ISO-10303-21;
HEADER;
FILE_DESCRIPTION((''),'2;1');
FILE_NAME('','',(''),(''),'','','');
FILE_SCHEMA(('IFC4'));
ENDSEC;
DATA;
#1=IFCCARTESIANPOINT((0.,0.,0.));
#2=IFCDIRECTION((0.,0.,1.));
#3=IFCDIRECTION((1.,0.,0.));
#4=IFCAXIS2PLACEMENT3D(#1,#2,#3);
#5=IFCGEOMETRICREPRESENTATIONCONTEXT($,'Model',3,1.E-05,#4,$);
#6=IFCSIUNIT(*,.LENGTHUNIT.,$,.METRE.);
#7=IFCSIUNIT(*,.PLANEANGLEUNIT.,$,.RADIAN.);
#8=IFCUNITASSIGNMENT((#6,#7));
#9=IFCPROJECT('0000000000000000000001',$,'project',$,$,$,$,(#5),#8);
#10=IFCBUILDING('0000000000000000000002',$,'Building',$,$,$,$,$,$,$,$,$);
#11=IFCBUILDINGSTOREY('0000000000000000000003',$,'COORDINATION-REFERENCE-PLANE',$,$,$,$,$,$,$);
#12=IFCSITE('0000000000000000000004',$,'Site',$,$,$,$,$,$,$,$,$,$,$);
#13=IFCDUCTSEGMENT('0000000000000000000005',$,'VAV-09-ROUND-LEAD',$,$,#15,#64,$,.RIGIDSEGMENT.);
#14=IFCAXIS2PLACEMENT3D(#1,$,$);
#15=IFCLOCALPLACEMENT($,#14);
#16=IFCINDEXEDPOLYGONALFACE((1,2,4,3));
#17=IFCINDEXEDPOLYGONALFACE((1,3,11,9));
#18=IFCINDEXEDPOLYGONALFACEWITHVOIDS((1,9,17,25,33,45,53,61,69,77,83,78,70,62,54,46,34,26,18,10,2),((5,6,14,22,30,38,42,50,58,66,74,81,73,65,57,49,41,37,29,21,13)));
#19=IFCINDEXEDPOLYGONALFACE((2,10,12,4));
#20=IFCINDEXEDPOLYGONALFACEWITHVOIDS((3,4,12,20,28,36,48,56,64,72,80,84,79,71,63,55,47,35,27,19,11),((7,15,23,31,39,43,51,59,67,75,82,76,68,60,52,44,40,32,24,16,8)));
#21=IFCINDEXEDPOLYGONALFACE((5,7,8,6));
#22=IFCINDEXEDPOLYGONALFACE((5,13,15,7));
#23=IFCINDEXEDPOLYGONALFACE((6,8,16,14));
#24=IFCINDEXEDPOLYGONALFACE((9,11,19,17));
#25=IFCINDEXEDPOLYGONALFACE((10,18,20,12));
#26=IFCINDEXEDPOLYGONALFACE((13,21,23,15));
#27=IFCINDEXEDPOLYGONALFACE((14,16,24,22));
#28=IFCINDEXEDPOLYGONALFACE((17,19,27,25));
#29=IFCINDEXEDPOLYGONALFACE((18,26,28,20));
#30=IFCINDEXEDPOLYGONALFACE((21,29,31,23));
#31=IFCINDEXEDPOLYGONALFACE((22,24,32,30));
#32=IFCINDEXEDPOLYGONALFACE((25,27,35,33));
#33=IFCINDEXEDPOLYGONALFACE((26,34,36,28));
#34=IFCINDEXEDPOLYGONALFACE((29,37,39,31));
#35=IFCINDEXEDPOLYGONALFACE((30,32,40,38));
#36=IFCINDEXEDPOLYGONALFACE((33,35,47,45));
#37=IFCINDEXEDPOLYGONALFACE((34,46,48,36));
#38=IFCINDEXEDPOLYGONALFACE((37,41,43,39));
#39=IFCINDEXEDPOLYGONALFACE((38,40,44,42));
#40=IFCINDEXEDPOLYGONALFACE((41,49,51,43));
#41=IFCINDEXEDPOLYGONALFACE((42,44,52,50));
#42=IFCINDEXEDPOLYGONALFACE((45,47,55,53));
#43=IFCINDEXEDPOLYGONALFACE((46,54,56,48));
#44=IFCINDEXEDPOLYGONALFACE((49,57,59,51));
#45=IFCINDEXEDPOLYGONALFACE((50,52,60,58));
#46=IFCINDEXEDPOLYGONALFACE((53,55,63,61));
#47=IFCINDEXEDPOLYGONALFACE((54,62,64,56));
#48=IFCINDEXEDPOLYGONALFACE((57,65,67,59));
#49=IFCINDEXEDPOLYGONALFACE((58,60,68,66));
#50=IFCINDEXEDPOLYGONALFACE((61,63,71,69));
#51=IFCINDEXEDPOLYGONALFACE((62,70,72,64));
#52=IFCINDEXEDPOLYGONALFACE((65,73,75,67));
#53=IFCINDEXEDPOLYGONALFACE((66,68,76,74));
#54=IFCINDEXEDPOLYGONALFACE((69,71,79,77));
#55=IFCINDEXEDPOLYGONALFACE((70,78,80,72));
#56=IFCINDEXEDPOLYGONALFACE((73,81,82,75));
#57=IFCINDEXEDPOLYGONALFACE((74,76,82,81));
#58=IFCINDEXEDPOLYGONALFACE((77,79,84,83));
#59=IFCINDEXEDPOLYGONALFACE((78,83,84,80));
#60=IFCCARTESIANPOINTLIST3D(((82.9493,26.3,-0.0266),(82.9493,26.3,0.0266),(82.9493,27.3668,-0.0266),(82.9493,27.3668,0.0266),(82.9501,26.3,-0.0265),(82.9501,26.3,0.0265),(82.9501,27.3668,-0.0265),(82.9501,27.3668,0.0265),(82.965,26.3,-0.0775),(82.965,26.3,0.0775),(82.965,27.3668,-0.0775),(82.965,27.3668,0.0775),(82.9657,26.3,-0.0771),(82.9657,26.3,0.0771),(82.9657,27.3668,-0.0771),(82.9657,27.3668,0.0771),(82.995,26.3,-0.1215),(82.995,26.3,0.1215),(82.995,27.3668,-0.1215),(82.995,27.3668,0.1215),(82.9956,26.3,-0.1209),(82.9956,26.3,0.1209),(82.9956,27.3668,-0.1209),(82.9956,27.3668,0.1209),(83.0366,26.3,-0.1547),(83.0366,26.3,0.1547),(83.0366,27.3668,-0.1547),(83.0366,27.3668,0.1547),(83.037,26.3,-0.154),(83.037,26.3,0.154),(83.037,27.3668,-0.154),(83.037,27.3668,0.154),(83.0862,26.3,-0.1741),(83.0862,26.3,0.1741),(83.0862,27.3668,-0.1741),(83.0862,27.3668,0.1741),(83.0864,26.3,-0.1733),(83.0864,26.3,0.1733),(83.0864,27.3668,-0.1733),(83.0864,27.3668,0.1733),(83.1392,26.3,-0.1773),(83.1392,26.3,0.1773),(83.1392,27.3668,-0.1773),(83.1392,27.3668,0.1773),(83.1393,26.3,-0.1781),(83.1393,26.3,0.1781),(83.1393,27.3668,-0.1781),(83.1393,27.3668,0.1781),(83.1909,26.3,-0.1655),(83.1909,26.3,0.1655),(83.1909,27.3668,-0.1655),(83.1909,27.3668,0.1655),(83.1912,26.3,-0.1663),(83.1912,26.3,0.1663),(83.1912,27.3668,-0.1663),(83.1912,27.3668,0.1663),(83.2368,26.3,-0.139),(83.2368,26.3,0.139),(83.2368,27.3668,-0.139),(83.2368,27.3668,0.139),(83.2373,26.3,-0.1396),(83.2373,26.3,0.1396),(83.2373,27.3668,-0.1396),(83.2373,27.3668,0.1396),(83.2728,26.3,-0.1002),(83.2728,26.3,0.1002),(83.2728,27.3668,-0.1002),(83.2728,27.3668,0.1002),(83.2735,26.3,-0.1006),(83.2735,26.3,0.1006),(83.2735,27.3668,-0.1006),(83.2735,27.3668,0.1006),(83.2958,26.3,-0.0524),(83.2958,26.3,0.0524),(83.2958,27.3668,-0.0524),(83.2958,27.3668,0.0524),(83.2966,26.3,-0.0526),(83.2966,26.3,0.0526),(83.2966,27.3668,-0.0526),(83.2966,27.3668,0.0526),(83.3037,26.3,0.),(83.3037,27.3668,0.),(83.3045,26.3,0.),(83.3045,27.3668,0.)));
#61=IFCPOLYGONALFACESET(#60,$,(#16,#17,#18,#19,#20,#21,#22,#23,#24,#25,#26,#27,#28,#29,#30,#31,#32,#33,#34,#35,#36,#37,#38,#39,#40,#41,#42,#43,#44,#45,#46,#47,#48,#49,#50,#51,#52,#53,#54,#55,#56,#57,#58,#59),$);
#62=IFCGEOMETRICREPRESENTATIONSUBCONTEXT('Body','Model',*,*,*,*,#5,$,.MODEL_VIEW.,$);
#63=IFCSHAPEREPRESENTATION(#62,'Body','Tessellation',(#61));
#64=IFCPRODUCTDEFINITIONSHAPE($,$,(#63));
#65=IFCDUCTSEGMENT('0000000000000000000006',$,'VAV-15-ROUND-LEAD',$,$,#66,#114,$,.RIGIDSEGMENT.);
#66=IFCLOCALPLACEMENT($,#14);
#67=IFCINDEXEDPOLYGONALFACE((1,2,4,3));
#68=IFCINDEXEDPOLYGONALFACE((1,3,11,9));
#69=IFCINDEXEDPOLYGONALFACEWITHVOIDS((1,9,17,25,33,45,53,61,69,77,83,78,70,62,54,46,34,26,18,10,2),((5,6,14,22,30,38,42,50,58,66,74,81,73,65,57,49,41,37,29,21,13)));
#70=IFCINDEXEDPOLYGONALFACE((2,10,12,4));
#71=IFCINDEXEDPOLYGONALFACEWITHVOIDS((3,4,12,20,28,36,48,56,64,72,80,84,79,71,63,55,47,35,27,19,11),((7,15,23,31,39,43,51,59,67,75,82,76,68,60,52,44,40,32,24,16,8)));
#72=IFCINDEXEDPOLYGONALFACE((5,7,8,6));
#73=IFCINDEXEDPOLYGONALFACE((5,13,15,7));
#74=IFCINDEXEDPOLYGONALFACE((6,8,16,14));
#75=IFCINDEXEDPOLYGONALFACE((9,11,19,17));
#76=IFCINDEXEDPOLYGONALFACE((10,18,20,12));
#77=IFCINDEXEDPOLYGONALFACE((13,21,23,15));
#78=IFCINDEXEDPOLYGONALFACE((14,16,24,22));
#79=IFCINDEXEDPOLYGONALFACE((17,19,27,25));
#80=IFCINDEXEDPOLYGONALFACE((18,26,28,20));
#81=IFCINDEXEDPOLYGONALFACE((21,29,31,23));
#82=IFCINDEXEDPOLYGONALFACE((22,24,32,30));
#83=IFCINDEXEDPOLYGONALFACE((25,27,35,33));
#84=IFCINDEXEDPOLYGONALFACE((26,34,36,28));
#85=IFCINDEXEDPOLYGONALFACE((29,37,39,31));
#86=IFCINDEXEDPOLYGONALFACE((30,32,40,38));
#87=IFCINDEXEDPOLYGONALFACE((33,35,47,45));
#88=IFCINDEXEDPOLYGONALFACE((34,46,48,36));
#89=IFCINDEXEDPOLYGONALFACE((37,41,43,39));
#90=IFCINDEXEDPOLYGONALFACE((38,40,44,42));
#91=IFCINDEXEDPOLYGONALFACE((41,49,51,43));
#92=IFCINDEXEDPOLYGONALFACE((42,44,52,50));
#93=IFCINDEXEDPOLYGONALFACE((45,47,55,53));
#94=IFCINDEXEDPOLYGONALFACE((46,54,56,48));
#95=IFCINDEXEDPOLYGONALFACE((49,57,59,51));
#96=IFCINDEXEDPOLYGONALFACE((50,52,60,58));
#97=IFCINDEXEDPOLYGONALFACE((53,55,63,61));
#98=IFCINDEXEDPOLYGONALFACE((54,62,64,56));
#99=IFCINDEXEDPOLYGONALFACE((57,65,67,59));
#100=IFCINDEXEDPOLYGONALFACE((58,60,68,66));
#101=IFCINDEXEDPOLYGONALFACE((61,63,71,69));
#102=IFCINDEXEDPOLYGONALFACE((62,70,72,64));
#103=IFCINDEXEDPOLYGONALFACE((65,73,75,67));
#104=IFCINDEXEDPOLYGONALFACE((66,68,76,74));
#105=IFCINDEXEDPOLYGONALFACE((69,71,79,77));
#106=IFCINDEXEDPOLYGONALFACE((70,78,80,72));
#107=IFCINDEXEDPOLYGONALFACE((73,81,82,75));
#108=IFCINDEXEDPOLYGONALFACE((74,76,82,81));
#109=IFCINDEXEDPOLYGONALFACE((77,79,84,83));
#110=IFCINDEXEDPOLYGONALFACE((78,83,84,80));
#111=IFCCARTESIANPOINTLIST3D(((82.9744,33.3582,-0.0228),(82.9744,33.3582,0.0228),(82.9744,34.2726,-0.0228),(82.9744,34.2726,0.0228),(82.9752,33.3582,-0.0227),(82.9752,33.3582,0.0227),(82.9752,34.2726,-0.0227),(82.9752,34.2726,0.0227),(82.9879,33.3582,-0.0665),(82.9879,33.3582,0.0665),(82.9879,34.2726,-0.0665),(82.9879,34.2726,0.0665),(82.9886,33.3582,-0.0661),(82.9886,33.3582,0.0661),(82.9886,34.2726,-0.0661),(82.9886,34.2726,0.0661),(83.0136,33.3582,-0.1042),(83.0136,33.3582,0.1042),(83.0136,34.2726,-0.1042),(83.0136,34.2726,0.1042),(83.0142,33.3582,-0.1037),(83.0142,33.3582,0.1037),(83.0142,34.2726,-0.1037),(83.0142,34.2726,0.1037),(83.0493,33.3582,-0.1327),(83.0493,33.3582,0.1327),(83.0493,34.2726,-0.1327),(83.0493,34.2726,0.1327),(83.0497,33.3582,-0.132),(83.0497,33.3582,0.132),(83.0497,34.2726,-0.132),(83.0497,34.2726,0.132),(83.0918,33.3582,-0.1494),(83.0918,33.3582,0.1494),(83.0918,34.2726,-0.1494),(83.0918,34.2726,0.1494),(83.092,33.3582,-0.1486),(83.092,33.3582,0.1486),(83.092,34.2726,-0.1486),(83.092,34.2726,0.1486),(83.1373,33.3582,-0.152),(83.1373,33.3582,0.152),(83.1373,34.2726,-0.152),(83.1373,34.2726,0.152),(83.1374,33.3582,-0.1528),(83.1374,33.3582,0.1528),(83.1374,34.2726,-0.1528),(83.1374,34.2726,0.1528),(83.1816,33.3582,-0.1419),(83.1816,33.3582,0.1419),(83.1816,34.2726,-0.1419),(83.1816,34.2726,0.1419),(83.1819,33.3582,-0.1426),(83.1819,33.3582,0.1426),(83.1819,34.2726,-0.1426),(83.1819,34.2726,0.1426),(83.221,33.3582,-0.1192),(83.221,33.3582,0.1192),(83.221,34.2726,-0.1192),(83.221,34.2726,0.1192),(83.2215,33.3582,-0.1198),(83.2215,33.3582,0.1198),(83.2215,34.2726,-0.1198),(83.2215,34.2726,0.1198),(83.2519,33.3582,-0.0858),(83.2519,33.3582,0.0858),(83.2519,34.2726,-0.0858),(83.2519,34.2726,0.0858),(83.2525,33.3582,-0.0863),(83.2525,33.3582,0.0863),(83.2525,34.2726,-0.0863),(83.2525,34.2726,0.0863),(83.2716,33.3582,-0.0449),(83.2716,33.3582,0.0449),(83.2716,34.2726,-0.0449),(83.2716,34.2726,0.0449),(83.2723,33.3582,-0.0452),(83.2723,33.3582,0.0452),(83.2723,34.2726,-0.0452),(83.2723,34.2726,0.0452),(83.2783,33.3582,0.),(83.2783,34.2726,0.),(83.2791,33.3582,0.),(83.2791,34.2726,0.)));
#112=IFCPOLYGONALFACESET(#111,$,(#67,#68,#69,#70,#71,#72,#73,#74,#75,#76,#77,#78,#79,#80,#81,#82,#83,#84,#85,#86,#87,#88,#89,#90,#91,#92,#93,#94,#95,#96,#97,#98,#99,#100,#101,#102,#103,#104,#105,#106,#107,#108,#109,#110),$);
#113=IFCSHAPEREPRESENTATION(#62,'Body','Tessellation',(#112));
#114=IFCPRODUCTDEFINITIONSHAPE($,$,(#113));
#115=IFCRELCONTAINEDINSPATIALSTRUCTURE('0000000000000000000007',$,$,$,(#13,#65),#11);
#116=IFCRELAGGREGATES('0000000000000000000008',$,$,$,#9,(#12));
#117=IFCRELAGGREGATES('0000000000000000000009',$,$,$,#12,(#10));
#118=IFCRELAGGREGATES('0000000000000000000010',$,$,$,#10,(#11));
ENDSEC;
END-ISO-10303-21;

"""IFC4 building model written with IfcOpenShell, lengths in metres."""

from ifc_helpers import new_model, si_unit, frame, origin, origin_with_axes, place, context, subcontext, project, spatial, hollow_circle, extrude, element, save


model = new_model("IFC4")

# Units and contexts
model_context_1 = context("Model", 3, precision=1e-05, world=origin_with_axes())
body_context_1 = subcontext(model_context_1, "Body", "Model", "MODEL_VIEW")
ifc_project = project(units=[si_unit("LENGTHUNIT", "METRE"), si_unit("PLANEANGLEUNIT", "RADIAN")], contexts=[model_context_1])

# Site, building, storey
site = spatial("IfcSite", under=ifc_project, Name="Site")
building = spatial("IfcBuilding", under=site, Name="Building")
storey = spatial("IfcBuildingStorey", under=building, Name="COORDINATION-REFERENCE-PLANE")

# Duct segments
duct_segment_1_placement = place(None, frame((83.1259, 27.3668, 0.0), z_axis=(0.0, -1.0, 0.0), x_axis=(1.0, 0.0, 0.0)))
element("IfcDuctSegment", 1, at=duct_segment_1_placement, inside=storey, Name="VAV-09-ROUND-LEAD", PredefinedType="RIGIDSEGMENT", context=body_context_1, shape_type="SweptSolid", body=[
    extrude(hollow_circle(Radius=0.1786, WallThickness=0.0008), origin(), (0.0, 0.0, 1.0), 1.0668),
])
duct_segment_2_placement = place(None, frame((83.1259, 34.2726, 0.0), z_axis=(0.0, -1.0, 0.0), x_axis=(1.0, 0.0, 0.0)))
element("IfcDuctSegment", 2, at=duct_segment_2_placement, inside=storey, Name="VAV-15-ROUND-LEAD", PredefinedType="RIGIDSEGMENT", context=body_context_1, shape_type="SweptSolid", body=[
    extrude(hollow_circle(Radius=0.1532, WallThickness=0.0008), origin(), (0.0, 0.0, 1.0), 0.9144),
])

save(model, "model.ifc")
